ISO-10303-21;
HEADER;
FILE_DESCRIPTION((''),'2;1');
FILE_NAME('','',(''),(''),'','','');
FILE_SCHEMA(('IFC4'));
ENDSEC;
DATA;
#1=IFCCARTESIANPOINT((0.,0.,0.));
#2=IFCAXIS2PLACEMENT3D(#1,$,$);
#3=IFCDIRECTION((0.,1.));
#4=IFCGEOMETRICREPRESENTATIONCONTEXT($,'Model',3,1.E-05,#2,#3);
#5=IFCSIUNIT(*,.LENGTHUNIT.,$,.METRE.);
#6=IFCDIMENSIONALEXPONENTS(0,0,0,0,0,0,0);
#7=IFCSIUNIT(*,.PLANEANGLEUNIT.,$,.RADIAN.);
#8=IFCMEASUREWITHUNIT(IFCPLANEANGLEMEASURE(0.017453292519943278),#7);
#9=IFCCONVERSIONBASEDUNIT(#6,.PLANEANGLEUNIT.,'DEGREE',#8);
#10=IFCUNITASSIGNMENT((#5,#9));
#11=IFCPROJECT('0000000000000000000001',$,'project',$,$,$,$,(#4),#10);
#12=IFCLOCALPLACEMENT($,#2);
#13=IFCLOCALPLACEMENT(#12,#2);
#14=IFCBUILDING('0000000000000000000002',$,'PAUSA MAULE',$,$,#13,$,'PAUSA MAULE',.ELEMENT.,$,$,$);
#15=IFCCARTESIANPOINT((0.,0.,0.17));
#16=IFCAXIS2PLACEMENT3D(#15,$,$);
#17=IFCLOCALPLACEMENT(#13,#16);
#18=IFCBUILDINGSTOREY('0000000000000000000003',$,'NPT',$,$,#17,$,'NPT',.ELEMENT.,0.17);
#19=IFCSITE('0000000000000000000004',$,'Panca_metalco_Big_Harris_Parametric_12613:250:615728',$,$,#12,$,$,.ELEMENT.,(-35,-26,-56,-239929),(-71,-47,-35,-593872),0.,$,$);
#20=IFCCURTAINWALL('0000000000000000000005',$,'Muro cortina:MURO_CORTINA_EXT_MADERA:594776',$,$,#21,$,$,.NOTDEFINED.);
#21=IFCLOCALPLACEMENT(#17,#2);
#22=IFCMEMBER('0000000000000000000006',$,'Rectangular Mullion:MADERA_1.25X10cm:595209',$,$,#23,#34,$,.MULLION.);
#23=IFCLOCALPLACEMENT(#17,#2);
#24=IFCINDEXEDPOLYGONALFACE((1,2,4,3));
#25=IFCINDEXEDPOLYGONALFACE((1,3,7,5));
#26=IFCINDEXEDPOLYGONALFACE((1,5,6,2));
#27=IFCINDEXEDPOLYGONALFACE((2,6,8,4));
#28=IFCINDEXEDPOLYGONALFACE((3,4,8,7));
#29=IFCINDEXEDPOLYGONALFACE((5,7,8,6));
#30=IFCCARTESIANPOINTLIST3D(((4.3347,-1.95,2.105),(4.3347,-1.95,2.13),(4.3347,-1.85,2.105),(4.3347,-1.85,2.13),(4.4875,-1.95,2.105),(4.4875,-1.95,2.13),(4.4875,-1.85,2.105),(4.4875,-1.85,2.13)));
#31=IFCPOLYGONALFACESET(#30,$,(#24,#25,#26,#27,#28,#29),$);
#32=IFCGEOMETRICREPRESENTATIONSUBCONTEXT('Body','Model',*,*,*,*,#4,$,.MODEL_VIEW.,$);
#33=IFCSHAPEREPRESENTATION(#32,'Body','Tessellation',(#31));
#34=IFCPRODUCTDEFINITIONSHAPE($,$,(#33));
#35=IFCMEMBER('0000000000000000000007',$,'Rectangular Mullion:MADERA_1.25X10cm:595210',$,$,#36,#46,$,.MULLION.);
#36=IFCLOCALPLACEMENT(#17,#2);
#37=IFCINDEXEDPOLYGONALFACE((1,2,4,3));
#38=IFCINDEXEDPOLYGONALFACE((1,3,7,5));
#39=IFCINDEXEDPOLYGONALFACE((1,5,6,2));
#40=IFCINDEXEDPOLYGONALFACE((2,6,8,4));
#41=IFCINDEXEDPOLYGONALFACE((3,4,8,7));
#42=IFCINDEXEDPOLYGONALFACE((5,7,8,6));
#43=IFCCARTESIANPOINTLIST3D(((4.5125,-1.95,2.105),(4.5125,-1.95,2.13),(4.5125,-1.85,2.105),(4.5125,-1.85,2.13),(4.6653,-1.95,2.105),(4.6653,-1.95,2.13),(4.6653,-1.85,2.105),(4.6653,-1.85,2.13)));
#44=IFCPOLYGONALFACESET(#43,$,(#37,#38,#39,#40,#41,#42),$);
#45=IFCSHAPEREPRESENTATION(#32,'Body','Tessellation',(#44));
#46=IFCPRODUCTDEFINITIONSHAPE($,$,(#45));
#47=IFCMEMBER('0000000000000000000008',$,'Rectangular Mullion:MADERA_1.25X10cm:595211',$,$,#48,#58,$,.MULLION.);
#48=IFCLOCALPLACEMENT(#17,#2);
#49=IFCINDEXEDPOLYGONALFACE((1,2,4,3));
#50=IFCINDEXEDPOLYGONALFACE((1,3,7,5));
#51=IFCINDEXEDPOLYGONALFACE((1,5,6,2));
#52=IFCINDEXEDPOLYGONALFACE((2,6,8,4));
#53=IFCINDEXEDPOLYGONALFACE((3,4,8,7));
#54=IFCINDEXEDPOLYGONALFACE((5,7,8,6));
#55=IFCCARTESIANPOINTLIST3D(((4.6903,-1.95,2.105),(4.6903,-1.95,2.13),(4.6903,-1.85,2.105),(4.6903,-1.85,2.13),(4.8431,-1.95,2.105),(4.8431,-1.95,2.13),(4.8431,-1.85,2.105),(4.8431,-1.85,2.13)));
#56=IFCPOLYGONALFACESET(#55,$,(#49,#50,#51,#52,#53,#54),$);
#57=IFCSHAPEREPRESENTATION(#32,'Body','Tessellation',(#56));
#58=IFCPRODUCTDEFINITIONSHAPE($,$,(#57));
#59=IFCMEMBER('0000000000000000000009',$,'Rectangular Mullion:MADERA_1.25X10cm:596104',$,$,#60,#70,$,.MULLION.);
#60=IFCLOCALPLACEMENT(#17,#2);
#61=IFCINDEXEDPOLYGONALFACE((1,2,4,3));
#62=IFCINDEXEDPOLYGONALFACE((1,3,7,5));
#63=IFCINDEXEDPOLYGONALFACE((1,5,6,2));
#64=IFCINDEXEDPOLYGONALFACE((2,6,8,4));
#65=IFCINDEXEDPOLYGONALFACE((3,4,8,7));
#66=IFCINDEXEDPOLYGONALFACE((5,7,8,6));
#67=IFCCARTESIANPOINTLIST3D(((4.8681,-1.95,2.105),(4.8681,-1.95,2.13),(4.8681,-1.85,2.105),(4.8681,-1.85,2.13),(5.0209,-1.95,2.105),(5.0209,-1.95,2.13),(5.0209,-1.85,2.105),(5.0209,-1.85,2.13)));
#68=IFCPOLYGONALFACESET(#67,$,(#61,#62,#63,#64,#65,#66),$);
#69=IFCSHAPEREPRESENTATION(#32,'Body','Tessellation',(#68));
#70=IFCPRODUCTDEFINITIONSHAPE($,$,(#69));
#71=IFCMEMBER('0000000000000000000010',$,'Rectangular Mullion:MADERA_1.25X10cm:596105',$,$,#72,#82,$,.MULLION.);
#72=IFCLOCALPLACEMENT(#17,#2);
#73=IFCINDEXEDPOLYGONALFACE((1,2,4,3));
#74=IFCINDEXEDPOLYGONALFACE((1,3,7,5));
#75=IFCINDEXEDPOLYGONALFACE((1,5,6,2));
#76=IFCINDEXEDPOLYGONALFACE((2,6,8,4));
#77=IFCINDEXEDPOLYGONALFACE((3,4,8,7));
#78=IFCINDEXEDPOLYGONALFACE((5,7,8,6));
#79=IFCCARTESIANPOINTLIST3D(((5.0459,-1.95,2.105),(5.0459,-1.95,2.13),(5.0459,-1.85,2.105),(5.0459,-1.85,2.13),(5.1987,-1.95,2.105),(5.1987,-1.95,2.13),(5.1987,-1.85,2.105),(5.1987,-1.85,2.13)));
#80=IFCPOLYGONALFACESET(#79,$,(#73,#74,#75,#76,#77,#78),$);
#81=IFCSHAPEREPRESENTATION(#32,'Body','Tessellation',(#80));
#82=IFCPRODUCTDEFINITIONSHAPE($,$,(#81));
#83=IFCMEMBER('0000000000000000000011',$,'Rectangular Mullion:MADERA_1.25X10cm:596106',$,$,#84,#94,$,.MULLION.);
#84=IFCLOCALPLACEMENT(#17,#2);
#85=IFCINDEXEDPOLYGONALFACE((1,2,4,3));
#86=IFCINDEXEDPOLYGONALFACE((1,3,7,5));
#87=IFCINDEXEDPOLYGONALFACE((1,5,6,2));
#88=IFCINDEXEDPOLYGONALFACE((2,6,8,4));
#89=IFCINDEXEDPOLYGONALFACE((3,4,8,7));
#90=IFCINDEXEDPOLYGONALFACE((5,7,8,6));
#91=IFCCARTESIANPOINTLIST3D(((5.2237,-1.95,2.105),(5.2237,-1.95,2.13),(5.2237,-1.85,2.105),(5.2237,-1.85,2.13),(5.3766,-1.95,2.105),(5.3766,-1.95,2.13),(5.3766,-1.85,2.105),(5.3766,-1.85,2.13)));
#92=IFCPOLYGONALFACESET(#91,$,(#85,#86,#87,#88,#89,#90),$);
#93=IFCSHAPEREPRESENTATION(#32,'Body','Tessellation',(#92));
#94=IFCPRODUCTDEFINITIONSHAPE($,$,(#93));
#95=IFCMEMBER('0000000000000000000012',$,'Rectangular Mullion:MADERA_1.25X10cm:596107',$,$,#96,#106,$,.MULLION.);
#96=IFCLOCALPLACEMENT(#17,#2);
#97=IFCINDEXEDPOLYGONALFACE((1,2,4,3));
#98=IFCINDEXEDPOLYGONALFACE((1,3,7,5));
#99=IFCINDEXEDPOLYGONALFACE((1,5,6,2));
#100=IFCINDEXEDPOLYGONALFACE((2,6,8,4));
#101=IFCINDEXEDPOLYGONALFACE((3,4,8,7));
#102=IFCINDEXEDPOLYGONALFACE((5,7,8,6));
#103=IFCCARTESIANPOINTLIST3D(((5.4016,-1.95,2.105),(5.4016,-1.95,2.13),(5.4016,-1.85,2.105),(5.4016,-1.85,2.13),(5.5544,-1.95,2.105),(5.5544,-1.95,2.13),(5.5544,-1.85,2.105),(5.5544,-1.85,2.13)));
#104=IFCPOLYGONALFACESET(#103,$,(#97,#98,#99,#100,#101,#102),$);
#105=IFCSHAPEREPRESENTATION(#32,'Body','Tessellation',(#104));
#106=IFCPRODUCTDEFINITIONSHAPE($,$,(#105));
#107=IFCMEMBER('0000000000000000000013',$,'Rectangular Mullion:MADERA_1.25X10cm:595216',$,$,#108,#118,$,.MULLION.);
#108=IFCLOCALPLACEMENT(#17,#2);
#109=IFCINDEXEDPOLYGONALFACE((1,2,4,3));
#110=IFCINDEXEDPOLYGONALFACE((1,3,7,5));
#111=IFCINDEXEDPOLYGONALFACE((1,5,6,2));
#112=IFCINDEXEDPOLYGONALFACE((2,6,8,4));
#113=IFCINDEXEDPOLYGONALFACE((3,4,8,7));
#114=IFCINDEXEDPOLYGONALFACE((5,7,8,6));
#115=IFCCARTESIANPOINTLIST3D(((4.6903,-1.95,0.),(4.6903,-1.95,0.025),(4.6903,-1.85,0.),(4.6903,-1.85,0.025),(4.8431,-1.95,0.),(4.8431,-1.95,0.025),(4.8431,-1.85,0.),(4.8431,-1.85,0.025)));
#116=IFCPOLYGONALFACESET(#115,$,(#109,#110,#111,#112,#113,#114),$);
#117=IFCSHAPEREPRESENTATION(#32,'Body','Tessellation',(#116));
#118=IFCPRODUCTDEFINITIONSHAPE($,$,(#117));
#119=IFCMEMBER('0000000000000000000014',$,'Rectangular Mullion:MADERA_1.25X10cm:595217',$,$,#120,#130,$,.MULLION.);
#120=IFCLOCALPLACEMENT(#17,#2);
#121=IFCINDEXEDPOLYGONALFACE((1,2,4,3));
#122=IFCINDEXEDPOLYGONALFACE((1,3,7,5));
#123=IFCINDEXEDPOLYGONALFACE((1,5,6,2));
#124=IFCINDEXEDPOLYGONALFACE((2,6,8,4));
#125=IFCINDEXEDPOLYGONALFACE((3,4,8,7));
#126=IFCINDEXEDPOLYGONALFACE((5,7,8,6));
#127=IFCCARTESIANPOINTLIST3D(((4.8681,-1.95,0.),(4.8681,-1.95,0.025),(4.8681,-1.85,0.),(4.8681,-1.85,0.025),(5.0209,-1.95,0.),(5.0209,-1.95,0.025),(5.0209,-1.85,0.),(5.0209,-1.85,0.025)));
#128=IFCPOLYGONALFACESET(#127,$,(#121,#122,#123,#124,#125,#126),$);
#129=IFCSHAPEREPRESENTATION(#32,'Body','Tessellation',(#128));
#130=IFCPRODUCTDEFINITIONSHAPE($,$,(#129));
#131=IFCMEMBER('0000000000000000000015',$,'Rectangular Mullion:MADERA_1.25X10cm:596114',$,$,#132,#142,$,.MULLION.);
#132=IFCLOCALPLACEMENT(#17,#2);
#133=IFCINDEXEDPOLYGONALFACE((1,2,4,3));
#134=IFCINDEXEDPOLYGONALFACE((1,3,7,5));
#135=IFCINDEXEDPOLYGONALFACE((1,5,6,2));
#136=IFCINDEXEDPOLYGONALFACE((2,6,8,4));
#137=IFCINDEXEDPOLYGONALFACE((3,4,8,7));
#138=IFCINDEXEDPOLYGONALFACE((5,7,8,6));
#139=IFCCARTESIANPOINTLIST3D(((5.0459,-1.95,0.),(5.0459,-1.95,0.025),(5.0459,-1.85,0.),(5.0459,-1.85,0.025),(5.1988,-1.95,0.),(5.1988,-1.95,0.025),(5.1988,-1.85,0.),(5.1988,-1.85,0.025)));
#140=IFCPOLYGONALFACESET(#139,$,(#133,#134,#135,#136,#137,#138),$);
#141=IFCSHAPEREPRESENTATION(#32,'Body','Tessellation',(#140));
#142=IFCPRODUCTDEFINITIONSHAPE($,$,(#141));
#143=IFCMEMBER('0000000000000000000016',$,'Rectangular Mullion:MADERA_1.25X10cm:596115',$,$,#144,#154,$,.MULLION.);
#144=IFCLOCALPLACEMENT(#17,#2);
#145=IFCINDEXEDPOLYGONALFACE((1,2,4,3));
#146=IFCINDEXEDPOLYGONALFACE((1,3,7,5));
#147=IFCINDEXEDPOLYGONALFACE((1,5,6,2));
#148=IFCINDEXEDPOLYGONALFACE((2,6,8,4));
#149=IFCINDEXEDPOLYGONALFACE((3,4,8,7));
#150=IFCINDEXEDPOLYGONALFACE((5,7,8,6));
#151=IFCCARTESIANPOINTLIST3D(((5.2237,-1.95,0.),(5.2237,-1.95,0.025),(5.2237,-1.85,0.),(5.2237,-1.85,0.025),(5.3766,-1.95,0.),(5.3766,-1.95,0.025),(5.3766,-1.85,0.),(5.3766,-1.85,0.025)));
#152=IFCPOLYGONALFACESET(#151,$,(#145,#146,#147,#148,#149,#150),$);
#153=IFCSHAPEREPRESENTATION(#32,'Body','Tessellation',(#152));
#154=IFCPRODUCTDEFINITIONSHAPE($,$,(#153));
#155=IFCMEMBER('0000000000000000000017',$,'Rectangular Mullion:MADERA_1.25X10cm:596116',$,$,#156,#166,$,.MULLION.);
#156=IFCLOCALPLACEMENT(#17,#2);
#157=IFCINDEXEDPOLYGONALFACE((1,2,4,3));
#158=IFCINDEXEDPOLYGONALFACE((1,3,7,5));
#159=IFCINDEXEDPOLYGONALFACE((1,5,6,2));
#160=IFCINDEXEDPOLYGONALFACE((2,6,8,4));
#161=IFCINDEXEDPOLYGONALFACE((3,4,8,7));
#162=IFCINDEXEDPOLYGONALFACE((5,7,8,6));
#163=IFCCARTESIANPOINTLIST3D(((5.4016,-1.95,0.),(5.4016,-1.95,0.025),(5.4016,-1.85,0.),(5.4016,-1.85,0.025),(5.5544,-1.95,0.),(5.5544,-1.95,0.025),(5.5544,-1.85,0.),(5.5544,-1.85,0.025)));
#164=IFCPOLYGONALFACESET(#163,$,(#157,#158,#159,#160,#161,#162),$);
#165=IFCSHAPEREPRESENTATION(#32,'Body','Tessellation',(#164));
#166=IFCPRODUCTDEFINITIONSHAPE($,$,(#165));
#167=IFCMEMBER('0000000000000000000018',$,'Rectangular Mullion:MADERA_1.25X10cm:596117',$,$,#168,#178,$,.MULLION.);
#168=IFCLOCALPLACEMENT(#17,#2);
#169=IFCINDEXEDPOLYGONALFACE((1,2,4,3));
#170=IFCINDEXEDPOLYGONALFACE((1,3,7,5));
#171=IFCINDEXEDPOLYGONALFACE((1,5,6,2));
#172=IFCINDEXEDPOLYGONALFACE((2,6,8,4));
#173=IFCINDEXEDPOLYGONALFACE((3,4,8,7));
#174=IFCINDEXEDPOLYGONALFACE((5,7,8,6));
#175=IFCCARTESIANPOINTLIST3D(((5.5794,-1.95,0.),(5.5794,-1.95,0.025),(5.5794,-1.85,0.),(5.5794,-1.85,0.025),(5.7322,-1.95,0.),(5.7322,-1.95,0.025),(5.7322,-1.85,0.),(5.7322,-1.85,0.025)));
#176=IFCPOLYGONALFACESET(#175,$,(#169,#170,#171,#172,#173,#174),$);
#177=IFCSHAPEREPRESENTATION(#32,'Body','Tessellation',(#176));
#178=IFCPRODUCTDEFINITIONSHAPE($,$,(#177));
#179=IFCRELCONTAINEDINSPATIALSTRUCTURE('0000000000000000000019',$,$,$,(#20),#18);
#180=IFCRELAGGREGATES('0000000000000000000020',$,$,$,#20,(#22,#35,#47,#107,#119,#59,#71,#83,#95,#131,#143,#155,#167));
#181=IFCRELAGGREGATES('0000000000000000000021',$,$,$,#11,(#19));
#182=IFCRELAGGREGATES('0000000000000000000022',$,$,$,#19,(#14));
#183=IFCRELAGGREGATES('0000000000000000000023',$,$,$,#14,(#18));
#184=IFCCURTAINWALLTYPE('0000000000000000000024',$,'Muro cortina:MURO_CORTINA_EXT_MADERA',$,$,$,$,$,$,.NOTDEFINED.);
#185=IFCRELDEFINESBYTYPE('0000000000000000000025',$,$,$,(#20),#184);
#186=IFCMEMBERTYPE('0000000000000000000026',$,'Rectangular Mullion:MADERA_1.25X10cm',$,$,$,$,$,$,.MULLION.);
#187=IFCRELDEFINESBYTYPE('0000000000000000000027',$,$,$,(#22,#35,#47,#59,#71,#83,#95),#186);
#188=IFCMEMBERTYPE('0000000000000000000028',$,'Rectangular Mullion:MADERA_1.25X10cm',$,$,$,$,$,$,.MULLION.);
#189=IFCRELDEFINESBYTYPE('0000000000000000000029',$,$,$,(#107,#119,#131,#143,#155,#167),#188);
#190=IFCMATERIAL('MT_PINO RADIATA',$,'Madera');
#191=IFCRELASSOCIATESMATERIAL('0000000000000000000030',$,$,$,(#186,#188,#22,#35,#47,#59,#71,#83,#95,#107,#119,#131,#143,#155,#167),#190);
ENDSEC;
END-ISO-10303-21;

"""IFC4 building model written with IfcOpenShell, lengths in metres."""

from ifc_helpers import new_model, entity, si_unit, converted_unit, direction, frame, frame_2d, origin, place, context, subcontext, project, spatial, rectangle, extrude, source, transform, mapped, material, material_profile, profile_set, profile_usage, type_object, type_shapes, element, aggregate, save


model = new_model("IFC4")

# Units and contexts
model_context = context("Model", 3, precision=1e-05, world=origin(), true_north=direction((0.0, 1.0)))
body_context = subcontext(model_context, "Body", "Model", "MODEL_VIEW")
ifc_project = project(units=[si_unit("LENGTHUNIT", "METRE"), converted_unit("PLANEANGLEUNIT", "DEGREE", entity("IfcPlaneAngleMeasure", 0.017453292519943278), si_unit("PLANEANGLEUNIT", "RADIAN"), dimensions=[0, 0, 0, 0, 0, 0, 0])], contexts=[model_context])

# Site, building, storey
site_placement = place(None, origin())
site = spatial("IfcSite", under=ifc_project, at=site_placement, Name="Panca_metalco_Big_Harris_Parametric_12613:250:615728", CompositionType="ELEMENT", RefLatitude=(-35, -26, -56, -239929), RefLongitude=(-71, -47, -35, -593872), RefElevation=0.0)
building_placement = place(site_placement, origin())
building = spatial("IfcBuilding", under=site, at=building_placement, Name="PAUSA MAULE", LongName="PAUSA MAULE", CompositionType="ELEMENT")
storey_placement = place(building_placement, frame((0.0, 0.0, 0.17)))
storey = spatial("IfcBuildingStorey", under=building, at=storey_placement, Name="NPT", LongName="NPT", CompositionType="ELEMENT", Elevation=0.17)

# Curtain wall, members
curtain_wall_type = type_object("IfcCurtainWallType", Name="Muro cortina:MURO_CORTINA_EXT_MADERA", PredefinedType="NOTDEFINED")
curtain_wall_placement = place(storey_placement, frame((0.0, 0.0, -0.17)))
curtain_wall = element("IfcCurtainWall", 1, at=curtain_wall_placement, inside=storey, type_object=curtain_wall_type, Name="Muro cortina:MURO_CORTINA_EXT_MADERA:594776", PredefinedType="NOTDEFINED")
ifc_material = material(Name="MT_PINO RADIATA", Category="Madera")
ifc_material_profile = material_profile(ifc_material, rectangle(XDim=0.025, YDim=0.1, at=frame_2d((0.0, 0.0), x_axis=(1.0, 0.0))), Name="MADERA_1.25X10cm")
ifc_profile_set = profile_set([ifc_material_profile], Name="MADERA_1.25X10cm")
ifc_profile_usage = profile_usage(ifc_profile_set)
member_type_1 = type_object("IfcMemberType", Name="Rectangular Mullion:MADERA_1.25X10cm", PredefinedType="MULLION", material=ifc_profile_set)
shared_shape_1 = source(origin(), body_context, "Body", "SweptSolid", [
    extrude(rectangle(XDim=0.025, YDim=0.1, at=frame_2d((0.0, 0.0), x_axis=(1.0, 0.0))), frame((-0.0125, 0.0, -0.1528), z_axis=(0.0, 0.0, 1.0), x_axis=(-1.0, 0.0, 0.0)), (0.0, 0.0, 1.0), 0.1528),
])
type_shapes(member_type_1, [shared_shape_1])
member_1_placement = place(curtain_wall_placement, frame((4.4875, -1.9, 2.3), z_axis=(1.0, 0.0, 0.0), x_axis=(0.0, 0.0, 1.0)))
member_1 = element("IfcMember", 2, at=member_1_placement, type_object=member_type_1, material=ifc_profile_usage, Name="Rectangular Mullion:MADERA_1.25X10cm:595209", PredefinedType="MULLION", context=body_context, shape_type="MappedRepresentation", body=[
    mapped(shared_shape_1, transform((0.0, 0.0, 0.0), scale=1.0)),
])
member_2_placement = place(curtain_wall_placement, frame((4.6653, -1.9, 2.3), z_axis=(1.0, 0.0, 0.0), x_axis=(0.0, 0.0, 1.0)))
member_2 = element("IfcMember", 3, at=member_2_placement, type_object=member_type_1, material=ifc_profile_usage, Name="Rectangular Mullion:MADERA_1.25X10cm:595210", PredefinedType="MULLION", context=body_context, shape_type="MappedRepresentation", body=[
    mapped(shared_shape_1, transform((0.0, 0.0, 0.0), scale=1.0)),
])
member_3_placement = place(curtain_wall_placement, frame((4.8431, -1.9, 2.3), z_axis=(1.0, 0.0, 0.0), x_axis=(0.0, 0.0, 1.0)))
member_3 = element("IfcMember", 4, at=member_3_placement, type_object=member_type_1, material=ifc_profile_usage, Name="Rectangular Mullion:MADERA_1.25X10cm:595211", PredefinedType="MULLION", context=body_context, shape_type="MappedRepresentation", body=[
    mapped(shared_shape_1, transform((0.0, 0.0, 0.0), scale=1.0)),
])
member_4_placement = place(curtain_wall_placement, frame((5.0209, -1.9, 2.3), z_axis=(1.0, 0.0, 0.0), x_axis=(0.0, 0.0, 1.0)))
member_4 = element("IfcMember", 5, at=member_4_placement, type_object=member_type_1, material=ifc_profile_usage, Name="Rectangular Mullion:MADERA_1.25X10cm:596104", PredefinedType="MULLION", context=body_context, shape_type="MappedRepresentation", body=[
    mapped(shared_shape_1, transform((0.0, 0.0, 0.0), scale=1.0)),
])
member_5_placement = place(curtain_wall_placement, frame((5.1987, -1.9, 2.3), z_axis=(1.0, 0.0, 0.0), x_axis=(0.0, 0.0, 1.0)))
member_5 = element("IfcMember", 6, at=member_5_placement, type_object=member_type_1, material=ifc_profile_usage, Name="Rectangular Mullion:MADERA_1.25X10cm:596105", PredefinedType="MULLION", context=body_context, shape_type="MappedRepresentation", body=[
    mapped(shared_shape_1, transform((0.0, 0.0, 0.0), scale=1.0)),
])
member_6_placement = place(curtain_wall_placement, frame((5.3766, -1.9, 2.3), z_axis=(1.0, 0.0, 0.0), x_axis=(0.0, 0.0, 1.0)))
member_6 = element("IfcMember", 7, at=member_6_placement, type_object=member_type_1, material=ifc_profile_usage, Name="Rectangular Mullion:MADERA_1.25X10cm:596106", PredefinedType="MULLION", context=body_context, shape_type="MappedRepresentation", body=[
    mapped(shared_shape_1, transform((0.0, 0.0, 0.0), scale=1.0)),
])
member_7_placement = place(curtain_wall_placement, frame((5.5544, -1.9, 2.3), z_axis=(1.0, 0.0, 0.0), x_axis=(0.0, 0.0, 1.0)))
member_7 = element("IfcMember", 8, at=member_7_placement, type_object=member_type_1, material=ifc_profile_usage, Name="Rectangular Mullion:MADERA_1.25X10cm:596107", PredefinedType="MULLION", context=body_context, shape_type="MappedRepresentation", body=[
    mapped(shared_shape_1, transform((0.0, 0.0, 0.0), scale=1.0)),
])
member_type_2 = type_object("IfcMemberType", Name="Rectangular Mullion:MADERA_1.25X10cm", PredefinedType="MULLION", material=ifc_profile_set)
shared_shape_2 = source(origin(), body_context, "Body", "SweptSolid", [
    extrude(rectangle(XDim=0.025, YDim=0.1, at=frame_2d((0.0, 0.0), x_axis=(1.0, 0.0))), frame((-0.0125, 0.0, -0.1528), z_axis=(0.0, 0.0, 1.0), x_axis=(-1.0, 0.0, 0.0)), (0.0, 0.0, 1.0), 0.1528),
])
type_shapes(member_type_2, [shared_shape_2])
member_8_placement = place(curtain_wall_placement, frame((4.6903, -1.9, 0.17), z_axis=(-1.0, 0.0, 0.0), x_axis=(0.0, 0.0, -1.0)))
member_8 = element("IfcMember", 9, at=member_8_placement, type_object=member_type_2, material=ifc_profile_usage, Name="Rectangular Mullion:MADERA_1.25X10cm:595216", PredefinedType="MULLION", context=body_context, shape_type="MappedRepresentation", body=[
    mapped(shared_shape_2, transform((0.0, 0.0, 0.0), scale=1.0)),
])
member_9_placement = place(curtain_wall_placement, frame((4.8681, -1.9, 0.17), z_axis=(-1.0, 0.0, 0.0), x_axis=(0.0, 0.0, -1.0)))
member_9 = element("IfcMember", 10, at=member_9_placement, type_object=member_type_2, material=ifc_profile_usage, Name="Rectangular Mullion:MADERA_1.25X10cm:595217", PredefinedType="MULLION", context=body_context, shape_type="MappedRepresentation", body=[
    mapped(shared_shape_2, transform((0.0, 0.0, 0.0), scale=1.0)),
])
member_10_placement = place(curtain_wall_placement, frame((5.0459, -1.9, 0.17), z_axis=(-1.0, 0.0, 0.0), x_axis=(0.0, 0.0, -1.0)))
member_10 = element("IfcMember", 11, at=member_10_placement, type_object=member_type_2, material=ifc_profile_usage, Name="Rectangular Mullion:MADERA_1.25X10cm:596114", PredefinedType="MULLION", context=body_context, shape_type="MappedRepresentation", body=[
    mapped(shared_shape_2, transform((0.0, 0.0, 0.0), scale=1.0)),
])
member_11_placement = place(curtain_wall_placement, frame((5.2237, -1.9, 0.17), z_axis=(-1.0, 0.0, 0.0), x_axis=(0.0, 0.0, -1.0)))
member_11 = element("IfcMember", 12, at=member_11_placement, type_object=member_type_2, material=ifc_profile_usage, Name="Rectangular Mullion:MADERA_1.25X10cm:596115", PredefinedType="MULLION", context=body_context, shape_type="MappedRepresentation", body=[
    mapped(shared_shape_2, transform((0.0, 0.0, 0.0), scale=1.0)),
])
member_12_placement = place(curtain_wall_placement, frame((5.4016, -1.9, 0.17), z_axis=(-1.0, 0.0, 0.0), x_axis=(0.0, 0.0, -1.0)))
member_12 = element("IfcMember", 13, at=member_12_placement, type_object=member_type_2, material=ifc_profile_usage, Name="Rectangular Mullion:MADERA_1.25X10cm:596116", PredefinedType="MULLION", context=body_context, shape_type="MappedRepresentation", body=[
    mapped(shared_shape_2, transform((0.0, 0.0, 0.0), scale=1.0)),
])
member_13_placement = place(curtain_wall_placement, frame((5.5794, -1.9, 0.17), z_axis=(-1.0, 0.0, 0.0), x_axis=(0.0, 0.0, -1.0)))
member_13 = element("IfcMember", 14, at=member_13_placement, type_object=member_type_2, material=ifc_profile_usage, Name="Rectangular Mullion:MADERA_1.25X10cm:596117", PredefinedType="MULLION", context=body_context, shape_type="MappedRepresentation", body=[
    mapped(shared_shape_2, transform((0.0, 0.0, 0.0), scale=1.0)),
])
aggregate(curtain_wall, [member_1, member_2, member_3, member_8, member_9, member_4, member_5, member_6, member_7, member_10, member_11, member_12, member_13])

save(model, "model.ifc")
